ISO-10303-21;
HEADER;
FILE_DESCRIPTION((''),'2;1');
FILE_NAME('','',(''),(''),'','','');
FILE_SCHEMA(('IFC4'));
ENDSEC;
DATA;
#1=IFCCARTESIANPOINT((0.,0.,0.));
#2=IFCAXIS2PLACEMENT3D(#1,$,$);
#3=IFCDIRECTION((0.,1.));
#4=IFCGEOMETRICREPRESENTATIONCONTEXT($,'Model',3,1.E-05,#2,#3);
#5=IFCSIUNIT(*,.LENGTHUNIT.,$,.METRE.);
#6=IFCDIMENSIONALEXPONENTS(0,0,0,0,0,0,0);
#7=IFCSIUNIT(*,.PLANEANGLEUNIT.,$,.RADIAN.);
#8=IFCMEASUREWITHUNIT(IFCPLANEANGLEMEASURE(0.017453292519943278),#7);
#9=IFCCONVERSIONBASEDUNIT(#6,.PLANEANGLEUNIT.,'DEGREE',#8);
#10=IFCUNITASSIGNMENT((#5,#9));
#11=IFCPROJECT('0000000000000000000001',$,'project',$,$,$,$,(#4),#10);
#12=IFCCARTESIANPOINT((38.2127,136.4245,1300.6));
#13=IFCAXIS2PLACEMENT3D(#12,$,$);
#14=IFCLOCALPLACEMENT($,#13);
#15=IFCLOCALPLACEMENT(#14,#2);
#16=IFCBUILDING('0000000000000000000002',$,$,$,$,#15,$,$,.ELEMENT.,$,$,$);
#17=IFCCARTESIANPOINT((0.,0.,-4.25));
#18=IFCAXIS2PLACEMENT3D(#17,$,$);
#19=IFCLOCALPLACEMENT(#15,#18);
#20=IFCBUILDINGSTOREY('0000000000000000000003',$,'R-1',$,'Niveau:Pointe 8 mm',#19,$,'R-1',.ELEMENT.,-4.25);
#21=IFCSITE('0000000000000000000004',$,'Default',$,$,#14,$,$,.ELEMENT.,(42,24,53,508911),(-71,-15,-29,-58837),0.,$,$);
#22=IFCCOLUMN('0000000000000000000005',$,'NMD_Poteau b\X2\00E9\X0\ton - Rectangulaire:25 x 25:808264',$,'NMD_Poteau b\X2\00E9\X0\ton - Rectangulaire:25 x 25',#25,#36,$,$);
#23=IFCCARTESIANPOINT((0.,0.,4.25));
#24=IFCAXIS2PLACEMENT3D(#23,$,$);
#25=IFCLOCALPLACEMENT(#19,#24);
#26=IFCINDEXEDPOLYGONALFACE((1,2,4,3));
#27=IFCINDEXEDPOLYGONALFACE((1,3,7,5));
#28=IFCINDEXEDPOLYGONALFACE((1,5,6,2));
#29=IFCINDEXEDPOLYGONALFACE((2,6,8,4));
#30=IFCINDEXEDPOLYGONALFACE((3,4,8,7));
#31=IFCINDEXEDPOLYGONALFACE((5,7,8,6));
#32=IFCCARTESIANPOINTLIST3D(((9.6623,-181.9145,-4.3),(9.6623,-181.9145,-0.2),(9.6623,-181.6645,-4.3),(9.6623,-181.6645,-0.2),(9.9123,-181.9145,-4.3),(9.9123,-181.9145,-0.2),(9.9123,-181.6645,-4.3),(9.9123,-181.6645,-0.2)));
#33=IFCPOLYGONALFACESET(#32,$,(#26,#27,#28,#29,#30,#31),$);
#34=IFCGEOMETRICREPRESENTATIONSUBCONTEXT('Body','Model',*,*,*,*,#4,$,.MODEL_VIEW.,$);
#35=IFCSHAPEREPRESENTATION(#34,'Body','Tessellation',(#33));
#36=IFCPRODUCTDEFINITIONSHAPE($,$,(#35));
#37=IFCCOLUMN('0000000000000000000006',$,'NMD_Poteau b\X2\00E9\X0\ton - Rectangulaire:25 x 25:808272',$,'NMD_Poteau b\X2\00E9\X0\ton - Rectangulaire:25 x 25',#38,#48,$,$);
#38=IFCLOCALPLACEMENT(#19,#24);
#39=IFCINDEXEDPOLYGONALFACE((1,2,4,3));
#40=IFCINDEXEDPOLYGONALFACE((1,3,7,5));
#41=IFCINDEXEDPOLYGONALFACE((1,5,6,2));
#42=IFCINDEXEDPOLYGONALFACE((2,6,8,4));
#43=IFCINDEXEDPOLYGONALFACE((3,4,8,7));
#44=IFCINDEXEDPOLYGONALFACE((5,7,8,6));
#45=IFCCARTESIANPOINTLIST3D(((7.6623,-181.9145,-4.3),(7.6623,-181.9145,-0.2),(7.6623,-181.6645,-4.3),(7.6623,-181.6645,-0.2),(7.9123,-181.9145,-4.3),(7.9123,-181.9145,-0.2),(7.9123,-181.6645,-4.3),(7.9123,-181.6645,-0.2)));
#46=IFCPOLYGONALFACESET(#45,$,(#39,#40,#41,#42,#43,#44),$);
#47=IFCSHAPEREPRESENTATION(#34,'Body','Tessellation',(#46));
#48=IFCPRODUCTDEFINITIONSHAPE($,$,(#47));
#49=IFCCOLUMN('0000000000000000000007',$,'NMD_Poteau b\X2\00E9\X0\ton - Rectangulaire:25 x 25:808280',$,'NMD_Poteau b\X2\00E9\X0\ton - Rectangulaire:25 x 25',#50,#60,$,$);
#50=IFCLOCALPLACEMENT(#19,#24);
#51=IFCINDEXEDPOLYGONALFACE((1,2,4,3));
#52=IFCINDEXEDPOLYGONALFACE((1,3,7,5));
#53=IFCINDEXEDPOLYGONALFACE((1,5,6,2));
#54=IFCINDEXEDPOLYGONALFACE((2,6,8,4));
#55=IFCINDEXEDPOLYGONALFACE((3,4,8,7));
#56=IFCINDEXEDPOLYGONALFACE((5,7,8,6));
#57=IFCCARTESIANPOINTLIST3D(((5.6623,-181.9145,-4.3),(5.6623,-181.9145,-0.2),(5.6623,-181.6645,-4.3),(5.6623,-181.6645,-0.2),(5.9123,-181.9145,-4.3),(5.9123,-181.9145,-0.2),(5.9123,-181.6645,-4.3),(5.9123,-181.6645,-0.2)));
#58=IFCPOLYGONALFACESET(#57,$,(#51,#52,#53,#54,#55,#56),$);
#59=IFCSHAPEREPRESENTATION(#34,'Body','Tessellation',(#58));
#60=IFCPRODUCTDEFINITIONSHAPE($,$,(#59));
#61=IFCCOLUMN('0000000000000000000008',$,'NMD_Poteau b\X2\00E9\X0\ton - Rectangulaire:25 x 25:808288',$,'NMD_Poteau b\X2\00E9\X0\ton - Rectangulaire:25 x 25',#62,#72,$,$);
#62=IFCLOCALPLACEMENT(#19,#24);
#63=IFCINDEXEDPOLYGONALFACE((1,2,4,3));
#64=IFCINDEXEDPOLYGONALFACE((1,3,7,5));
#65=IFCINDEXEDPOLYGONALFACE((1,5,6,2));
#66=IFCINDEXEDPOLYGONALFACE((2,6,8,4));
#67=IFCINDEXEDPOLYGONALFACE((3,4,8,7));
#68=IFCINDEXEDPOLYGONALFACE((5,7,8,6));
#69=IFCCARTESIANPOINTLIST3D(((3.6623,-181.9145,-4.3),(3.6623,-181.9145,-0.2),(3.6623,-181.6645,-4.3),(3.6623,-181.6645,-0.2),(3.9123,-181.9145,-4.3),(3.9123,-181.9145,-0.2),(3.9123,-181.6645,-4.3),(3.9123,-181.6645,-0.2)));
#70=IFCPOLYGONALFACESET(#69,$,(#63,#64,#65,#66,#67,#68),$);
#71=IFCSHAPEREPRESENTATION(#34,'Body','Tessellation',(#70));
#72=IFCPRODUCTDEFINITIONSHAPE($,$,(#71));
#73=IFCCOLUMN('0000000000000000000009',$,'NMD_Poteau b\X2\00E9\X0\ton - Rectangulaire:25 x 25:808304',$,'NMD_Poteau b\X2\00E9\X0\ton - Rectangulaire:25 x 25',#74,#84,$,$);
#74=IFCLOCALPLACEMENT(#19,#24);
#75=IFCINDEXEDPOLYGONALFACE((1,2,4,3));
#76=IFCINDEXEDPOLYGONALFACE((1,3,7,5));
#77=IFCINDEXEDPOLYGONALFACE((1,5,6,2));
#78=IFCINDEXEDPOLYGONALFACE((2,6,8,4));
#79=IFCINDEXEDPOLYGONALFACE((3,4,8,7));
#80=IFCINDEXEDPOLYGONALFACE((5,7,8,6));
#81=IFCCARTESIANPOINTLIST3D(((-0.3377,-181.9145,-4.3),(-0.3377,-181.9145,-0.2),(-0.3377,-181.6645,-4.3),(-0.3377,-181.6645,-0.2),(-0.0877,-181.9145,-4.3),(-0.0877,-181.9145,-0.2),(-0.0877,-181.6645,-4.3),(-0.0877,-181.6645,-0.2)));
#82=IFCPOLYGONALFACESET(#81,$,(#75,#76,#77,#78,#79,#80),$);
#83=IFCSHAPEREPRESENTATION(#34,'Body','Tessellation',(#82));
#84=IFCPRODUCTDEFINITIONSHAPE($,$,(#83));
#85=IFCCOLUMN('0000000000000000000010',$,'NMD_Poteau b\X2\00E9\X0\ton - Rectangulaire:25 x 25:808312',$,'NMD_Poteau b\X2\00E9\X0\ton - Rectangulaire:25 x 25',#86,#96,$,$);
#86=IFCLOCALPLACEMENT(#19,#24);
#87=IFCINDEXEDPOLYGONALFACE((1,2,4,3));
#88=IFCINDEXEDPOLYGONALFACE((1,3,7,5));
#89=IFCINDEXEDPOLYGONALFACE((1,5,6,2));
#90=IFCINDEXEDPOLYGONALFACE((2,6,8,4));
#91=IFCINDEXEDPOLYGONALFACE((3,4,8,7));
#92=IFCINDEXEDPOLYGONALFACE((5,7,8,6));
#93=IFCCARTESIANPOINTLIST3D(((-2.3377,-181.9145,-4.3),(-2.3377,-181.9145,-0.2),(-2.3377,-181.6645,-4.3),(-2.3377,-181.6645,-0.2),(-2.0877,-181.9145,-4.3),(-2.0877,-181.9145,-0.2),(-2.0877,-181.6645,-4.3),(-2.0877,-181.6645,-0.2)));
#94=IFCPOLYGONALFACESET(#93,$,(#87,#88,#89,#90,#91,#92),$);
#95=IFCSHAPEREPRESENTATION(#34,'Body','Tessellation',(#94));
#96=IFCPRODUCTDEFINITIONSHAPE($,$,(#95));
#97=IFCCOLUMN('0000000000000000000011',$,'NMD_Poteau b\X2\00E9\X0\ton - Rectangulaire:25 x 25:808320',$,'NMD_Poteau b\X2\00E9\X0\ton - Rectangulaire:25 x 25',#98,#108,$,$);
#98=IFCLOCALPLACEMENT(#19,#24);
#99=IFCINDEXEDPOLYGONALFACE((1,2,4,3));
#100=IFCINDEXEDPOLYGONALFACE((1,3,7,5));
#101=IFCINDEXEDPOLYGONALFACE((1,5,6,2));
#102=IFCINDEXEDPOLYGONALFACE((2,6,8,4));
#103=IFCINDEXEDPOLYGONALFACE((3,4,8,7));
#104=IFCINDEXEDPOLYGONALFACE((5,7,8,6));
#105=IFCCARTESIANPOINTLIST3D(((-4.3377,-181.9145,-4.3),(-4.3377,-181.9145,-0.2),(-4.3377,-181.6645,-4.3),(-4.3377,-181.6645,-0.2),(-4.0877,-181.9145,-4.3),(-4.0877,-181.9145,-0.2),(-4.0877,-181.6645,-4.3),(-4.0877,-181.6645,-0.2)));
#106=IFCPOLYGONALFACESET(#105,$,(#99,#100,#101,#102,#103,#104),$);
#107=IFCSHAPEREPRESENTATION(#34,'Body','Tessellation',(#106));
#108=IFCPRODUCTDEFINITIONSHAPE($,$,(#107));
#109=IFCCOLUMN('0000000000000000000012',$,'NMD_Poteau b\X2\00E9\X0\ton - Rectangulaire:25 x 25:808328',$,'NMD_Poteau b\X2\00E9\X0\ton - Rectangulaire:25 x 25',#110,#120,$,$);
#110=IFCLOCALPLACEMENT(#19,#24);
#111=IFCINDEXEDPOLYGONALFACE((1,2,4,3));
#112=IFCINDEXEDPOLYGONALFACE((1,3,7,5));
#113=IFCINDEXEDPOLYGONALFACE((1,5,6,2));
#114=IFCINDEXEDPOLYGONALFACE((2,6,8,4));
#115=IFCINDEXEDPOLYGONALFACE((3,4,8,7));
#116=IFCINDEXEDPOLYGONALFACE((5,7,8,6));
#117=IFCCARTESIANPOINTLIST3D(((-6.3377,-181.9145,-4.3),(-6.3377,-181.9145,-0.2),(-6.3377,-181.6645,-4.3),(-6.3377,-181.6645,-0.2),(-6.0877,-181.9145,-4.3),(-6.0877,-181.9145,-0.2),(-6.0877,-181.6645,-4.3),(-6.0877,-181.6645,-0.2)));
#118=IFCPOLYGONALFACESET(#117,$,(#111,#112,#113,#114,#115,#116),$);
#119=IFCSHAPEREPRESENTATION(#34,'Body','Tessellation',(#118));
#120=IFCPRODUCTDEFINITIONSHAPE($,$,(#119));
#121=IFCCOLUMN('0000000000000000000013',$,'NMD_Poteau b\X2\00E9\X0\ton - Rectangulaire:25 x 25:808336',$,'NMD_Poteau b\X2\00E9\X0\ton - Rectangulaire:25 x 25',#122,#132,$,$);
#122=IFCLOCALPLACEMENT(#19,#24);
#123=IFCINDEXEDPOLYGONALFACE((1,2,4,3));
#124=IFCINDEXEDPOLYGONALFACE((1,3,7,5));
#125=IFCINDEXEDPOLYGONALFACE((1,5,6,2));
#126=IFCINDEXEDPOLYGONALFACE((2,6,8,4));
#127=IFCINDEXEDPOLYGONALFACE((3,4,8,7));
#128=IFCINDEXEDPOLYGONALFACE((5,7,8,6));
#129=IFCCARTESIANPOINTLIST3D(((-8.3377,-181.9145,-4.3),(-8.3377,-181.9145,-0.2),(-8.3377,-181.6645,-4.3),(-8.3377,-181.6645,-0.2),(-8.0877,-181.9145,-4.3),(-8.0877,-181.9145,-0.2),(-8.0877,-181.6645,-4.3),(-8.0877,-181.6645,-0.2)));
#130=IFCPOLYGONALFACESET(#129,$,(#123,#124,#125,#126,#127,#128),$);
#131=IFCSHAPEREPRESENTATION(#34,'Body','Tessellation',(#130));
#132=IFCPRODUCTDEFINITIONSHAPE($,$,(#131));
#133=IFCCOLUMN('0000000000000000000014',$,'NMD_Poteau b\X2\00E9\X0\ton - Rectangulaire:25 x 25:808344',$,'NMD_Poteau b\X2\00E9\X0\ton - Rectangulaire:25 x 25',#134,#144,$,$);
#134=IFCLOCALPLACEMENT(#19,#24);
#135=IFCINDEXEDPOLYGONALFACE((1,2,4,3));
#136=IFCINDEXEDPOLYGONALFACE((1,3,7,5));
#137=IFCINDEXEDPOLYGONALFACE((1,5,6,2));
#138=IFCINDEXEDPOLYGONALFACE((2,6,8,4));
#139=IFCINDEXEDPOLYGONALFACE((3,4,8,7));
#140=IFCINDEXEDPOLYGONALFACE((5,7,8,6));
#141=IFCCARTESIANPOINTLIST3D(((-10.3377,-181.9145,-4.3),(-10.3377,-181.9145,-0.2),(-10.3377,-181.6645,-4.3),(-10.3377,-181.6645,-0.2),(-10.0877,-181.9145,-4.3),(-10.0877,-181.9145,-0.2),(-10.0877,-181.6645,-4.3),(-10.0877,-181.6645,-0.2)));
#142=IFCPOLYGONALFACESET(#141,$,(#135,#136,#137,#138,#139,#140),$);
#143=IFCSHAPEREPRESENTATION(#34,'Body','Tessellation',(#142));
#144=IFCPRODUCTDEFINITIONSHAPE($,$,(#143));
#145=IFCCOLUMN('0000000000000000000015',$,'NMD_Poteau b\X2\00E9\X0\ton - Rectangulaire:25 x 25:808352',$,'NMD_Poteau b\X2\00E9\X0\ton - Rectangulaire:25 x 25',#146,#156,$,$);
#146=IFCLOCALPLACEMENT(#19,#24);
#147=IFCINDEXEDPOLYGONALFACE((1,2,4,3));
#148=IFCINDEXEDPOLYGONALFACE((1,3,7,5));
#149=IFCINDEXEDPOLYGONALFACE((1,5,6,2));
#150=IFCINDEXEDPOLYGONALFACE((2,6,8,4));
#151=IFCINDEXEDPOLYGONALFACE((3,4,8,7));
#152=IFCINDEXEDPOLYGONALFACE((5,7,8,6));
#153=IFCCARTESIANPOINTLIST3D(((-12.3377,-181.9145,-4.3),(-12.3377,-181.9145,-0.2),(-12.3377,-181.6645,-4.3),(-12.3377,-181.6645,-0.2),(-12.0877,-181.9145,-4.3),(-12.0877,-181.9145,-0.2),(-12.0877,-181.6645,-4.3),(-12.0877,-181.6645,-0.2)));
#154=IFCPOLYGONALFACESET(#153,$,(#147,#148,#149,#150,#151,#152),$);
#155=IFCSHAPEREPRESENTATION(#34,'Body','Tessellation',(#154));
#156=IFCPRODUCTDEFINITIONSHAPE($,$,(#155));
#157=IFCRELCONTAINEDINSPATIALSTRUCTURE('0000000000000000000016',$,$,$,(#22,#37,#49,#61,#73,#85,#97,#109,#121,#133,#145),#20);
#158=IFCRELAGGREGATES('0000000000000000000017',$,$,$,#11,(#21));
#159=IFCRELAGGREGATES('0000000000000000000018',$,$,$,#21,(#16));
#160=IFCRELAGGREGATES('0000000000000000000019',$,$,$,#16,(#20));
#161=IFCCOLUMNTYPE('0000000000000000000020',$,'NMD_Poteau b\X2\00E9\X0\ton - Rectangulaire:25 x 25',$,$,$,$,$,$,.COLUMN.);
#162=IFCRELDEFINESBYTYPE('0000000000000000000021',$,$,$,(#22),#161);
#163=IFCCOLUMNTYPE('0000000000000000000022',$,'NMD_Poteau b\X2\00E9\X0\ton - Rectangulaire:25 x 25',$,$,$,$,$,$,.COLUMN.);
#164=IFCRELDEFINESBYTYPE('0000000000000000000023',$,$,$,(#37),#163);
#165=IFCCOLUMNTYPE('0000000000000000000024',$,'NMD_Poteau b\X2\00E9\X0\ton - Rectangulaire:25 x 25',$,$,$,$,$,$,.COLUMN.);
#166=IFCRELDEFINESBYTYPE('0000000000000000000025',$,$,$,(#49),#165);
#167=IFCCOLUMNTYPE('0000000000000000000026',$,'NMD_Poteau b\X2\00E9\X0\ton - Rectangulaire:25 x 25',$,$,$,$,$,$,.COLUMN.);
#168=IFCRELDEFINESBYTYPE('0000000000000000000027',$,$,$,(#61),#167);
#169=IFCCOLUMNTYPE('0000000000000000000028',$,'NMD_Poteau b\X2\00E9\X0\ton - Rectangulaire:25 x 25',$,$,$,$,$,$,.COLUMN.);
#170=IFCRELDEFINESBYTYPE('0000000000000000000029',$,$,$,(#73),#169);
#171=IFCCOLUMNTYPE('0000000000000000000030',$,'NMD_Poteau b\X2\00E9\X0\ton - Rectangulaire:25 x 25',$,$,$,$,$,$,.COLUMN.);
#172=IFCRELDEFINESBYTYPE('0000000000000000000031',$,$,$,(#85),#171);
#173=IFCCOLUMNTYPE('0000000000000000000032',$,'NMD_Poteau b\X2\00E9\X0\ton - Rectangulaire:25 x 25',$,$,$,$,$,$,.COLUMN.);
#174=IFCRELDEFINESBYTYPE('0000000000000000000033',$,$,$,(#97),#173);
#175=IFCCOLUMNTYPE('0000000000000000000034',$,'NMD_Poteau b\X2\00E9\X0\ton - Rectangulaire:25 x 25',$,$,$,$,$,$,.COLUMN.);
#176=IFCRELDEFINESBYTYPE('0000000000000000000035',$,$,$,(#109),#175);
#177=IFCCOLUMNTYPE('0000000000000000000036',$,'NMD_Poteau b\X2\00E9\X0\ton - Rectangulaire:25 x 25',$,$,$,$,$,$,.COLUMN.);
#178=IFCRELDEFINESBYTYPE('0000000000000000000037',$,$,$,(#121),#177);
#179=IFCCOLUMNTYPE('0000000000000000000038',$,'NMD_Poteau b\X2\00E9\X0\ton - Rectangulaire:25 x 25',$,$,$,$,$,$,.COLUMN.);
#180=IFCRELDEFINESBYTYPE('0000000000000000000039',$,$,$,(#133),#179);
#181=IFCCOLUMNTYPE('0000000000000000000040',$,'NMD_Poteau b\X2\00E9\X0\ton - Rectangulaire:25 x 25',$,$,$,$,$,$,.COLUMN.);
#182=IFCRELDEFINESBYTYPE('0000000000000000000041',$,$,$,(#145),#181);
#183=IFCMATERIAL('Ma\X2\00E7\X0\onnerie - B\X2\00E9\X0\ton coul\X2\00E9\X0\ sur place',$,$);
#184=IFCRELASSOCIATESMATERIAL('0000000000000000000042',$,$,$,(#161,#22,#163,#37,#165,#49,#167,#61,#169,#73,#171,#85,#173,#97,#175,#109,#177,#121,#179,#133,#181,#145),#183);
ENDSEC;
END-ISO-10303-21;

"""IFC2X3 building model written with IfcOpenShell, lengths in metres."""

from ifc_helpers import new_model, entity, si_unit, converted_unit, direction, frame, frame_2d, origin, place, context, subcontext, project, spatial, rectangle, extrude, source, transform, mapped, material, type_object, type_shapes, element, save


model = new_model("IFC2X3")

# Units and contexts
model_context = context("Model", 3, precision=1e-05, world=origin(), true_north=direction((0.0, 1.0)))
body_context = subcontext(model_context, "Body", "Model", "MODEL_VIEW")
ifc_project = project(units=[si_unit("LENGTHUNIT", "METRE"), converted_unit("PLANEANGLEUNIT", "DEGREE", entity("IfcPlaneAngleMeasure", 0.017453292519943278), si_unit("PLANEANGLEUNIT", "RADIAN"), dimensions=[0, 0, 0, 0, 0, 0, 0])], contexts=[model_context])

# Site, building, storey
site_placement = place(None, frame((38.2127, 136.4245, 1300.6)))
site = spatial("IfcSite", under=ifc_project, at=site_placement, Name="Default", CompositionType="ELEMENT", RefLatitude=(42, 24, 53, 508911), RefLongitude=(-71, -15, -29, -58837), RefElevation=0.0)
building_placement = place(site_placement, origin())
building = spatial("IfcBuilding", under=site, at=building_placement, CompositionType="ELEMENT")
storey_placement = place(building_placement, frame((0.0, 0.0, -4.25)))
storey = spatial("IfcBuildingStorey", under=building, at=storey_placement, Name="R-1", ObjectType="Niveau:Pointe 8 mm", LongName="R-1", CompositionType="ELEMENT", Elevation=-4.25)

# Columns
ifc_material = material(Name="Maçonnerie - Béton coulé sur place")
column_type_1 = type_object("IfcColumnType", Name="NMD_Poteau béton - Rectangulaire:25 x 25", PredefinedType="COLUMN", material=ifc_material)
shared_shape_1 = source(origin(), body_context, "Body", "SweptSolid", [
    extrude(rectangle(XDim=0.25, YDim=0.25, at=frame_2d((0.0, 0.0), x_axis=(1.0, 0.0))), frame((9.7873, -181.7895, -4.3), z_axis=(0.0, 0.0, 1.0), x_axis=(-1.0, 0.0, 0.0)), (0.0, 0.0, 1.0), 4.1),
])
type_shapes(column_type_1, [shared_shape_1])
column_1_placement = place(storey_placement, frame((0.0, 0.0, 4.25)))
element("IfcColumn", 1, at=column_1_placement, inside=storey, type_object=column_type_1, material=ifc_material, Name="NMD_Poteau béton - Rectangulaire:25 x 25:808264", ObjectType="NMD_Poteau béton - Rectangulaire:25 x 25", context=body_context, shape_type="MappedRepresentation", body=[
    mapped(shared_shape_1, transform((0.0, 0.0, 0.0), scale=1.0)),
])
column_type_2 = type_object("IfcColumnType", Name="NMD_Poteau béton - Rectangulaire:25 x 25", PredefinedType="COLUMN", material=ifc_material)
shared_shape_2 = source(origin(), body_context, "Body", "SweptSolid", [
    extrude(rectangle(XDim=0.25, YDim=0.25, at=frame_2d((0.0, 0.0), x_axis=(1.0, 0.0))), frame((7.7873, -181.7895, -4.3), z_axis=(0.0, 0.0, 1.0), x_axis=(-1.0, 0.0, 0.0)), (0.0, 0.0, 1.0), 4.1),
])
type_shapes(column_type_2, [shared_shape_2])
column_2_placement = place(storey_placement, frame((0.0, 0.0, 4.25)))
element("IfcColumn", 2, at=column_2_placement, inside=storey, type_object=column_type_2, material=ifc_material, Name="NMD_Poteau béton - Rectangulaire:25 x 25:808272", ObjectType="NMD_Poteau béton - Rectangulaire:25 x 25", context=body_context, shape_type="MappedRepresentation", body=[
    mapped(shared_shape_2, transform((0.0, 0.0, 0.0), scale=1.0)),
])
column_type_3 = type_object("IfcColumnType", Name="NMD_Poteau béton - Rectangulaire:25 x 25", PredefinedType="COLUMN", material=ifc_material)
shared_shape_3 = source(origin(), body_context, "Body", "SweptSolid", [
    extrude(rectangle(XDim=0.25, YDim=0.25, at=frame_2d((0.0, 0.0), x_axis=(1.0, 0.0))), frame((5.7873, -181.7895, -4.3), z_axis=(0.0, 0.0, 1.0), x_axis=(-1.0, 0.0, 0.0)), (0.0, 0.0, 1.0), 4.1),
])
type_shapes(column_type_3, [shared_shape_3])
column_3_placement = place(storey_placement, frame((0.0, 0.0, 4.25)))
element("IfcColumn", 3, at=column_3_placement, inside=storey, type_object=column_type_3, material=ifc_material, Name="NMD_Poteau béton - Rectangulaire:25 x 25:808280", ObjectType="NMD_Poteau béton - Rectangulaire:25 x 25", context=body_context, shape_type="MappedRepresentation", body=[
    mapped(shared_shape_3, transform((0.0, 0.0, 0.0), scale=1.0)),
])
column_type_4 = type_object("IfcColumnType", Name="NMD_Poteau béton - Rectangulaire:25 x 25", PredefinedType="COLUMN", material=ifc_material)
shared_shape_4 = source(origin(), body_context, "Body", "SweptSolid", [
    extrude(rectangle(XDim=0.25, YDim=0.25, at=frame_2d((0.0, 0.0), x_axis=(1.0, 0.0))), frame((3.7873, -181.7895, -4.3), z_axis=(0.0, 0.0, 1.0), x_axis=(-1.0, 0.0, 0.0)), (0.0, 0.0, 1.0), 4.1),
])
type_shapes(column_type_4, [shared_shape_4])
column_4_placement = place(storey_placement, frame((0.0, 0.0, 4.25)))
element("IfcColumn", 4, at=column_4_placement, inside=storey, type_object=column_type_4, material=ifc_material, Name="NMD_Poteau béton - Rectangulaire:25 x 25:808288", ObjectType="NMD_Poteau béton - Rectangulaire:25 x 25", context=body_context, shape_type="MappedRepresentation", body=[
    mapped(shared_shape_4, transform((0.0, 0.0, 0.0), scale=1.0)),
])
column_type_5 = type_object("IfcColumnType", Name="NMD_Poteau béton - Rectangulaire:25 x 25", PredefinedType="COLUMN", material=ifc_material)
shared_shape_5 = source(origin(), body_context, "Body", "SweptSolid", [
    extrude(rectangle(XDim=0.25, YDim=0.25, at=frame_2d((0.0, 0.0), x_axis=(1.0, 0.0))), frame((-0.2127, -181.7895, -4.3), z_axis=(0.0, 0.0, 1.0), x_axis=(-1.0, 0.0, 0.0)), (0.0, 0.0, 1.0), 4.1),
])
type_shapes(column_type_5, [shared_shape_5])
column_5_placement = place(storey_placement, frame((0.0, 0.0, 4.25)))
element("IfcColumn", 5, at=column_5_placement, inside=storey, type_object=column_type_5, material=ifc_material, Name="NMD_Poteau béton - Rectangulaire:25 x 25:808304", ObjectType="NMD_Poteau béton - Rectangulaire:25 x 25", context=body_context, shape_type="MappedRepresentation", body=[
    mapped(shared_shape_5, transform((0.0, 0.0, 0.0), scale=1.0)),
])
column_type_6 = type_object("IfcColumnType", Name="NMD_Poteau béton - Rectangulaire:25 x 25", PredefinedType="COLUMN", material=ifc_material)
shared_shape_6 = source(origin(), body_context, "Body", "SweptSolid", [
    extrude(rectangle(XDim=0.25, YDim=0.25, at=frame_2d((0.0, 0.0), x_axis=(1.0, 0.0))), frame((-2.2127, -181.7895, -4.3), z_axis=(0.0, 0.0, 1.0), x_axis=(-1.0, 0.0, 0.0)), (0.0, 0.0, 1.0), 4.1),
])
type_shapes(column_type_6, [shared_shape_6])
column_6_placement = place(storey_placement, frame((0.0, 0.0, 4.25)))
element("IfcColumn", 6, at=column_6_placement, inside=storey, type_object=column_type_6, material=ifc_material, Name="NMD_Poteau béton - Rectangulaire:25 x 25:808312", ObjectType="NMD_Poteau béton - Rectangulaire:25 x 25", context=body_context, shape_type="MappedRepresentation", body=[
    mapped(shared_shape_6, transform((0.0, 0.0, 0.0), scale=1.0)),
])
column_type_7 = type_object("IfcColumnType", Name="NMD_Poteau béton - Rectangulaire:25 x 25", PredefinedType="COLUMN", material=ifc_material)
shared_shape_7 = source(origin(), body_context, "Body", "SweptSolid", [
    extrude(rectangle(XDim=0.25, YDim=0.25, at=frame_2d((0.0, 0.0), x_axis=(1.0, 0.0))), frame((-4.2127, -181.7895, -4.3), z_axis=(0.0, 0.0, 1.0), x_axis=(-1.0, 0.0, 0.0)), (0.0, 0.0, 1.0), 4.1),
])
type_shapes(column_type_7, [shared_shape_7])
column_7_placement = place(storey_placement, frame((0.0, 0.0, 4.25)))
element("IfcColumn", 7, at=column_7_placement, inside=storey, type_object=column_type_7, material=ifc_material, Name="NMD_Poteau béton - Rectangulaire:25 x 25:808320", ObjectType="NMD_Poteau béton - Rectangulaire:25 x 25", context=body_context, shape_type="MappedRepresentation", body=[
    mapped(shared_shape_7, transform((0.0, 0.0, 0.0), scale=1.0)),
])
column_type_8 = type_object("IfcColumnType", Name="NMD_Poteau béton - Rectangulaire:25 x 25", PredefinedType="COLUMN", material=ifc_material)
shared_shape_8 = source(origin(), body_context, "Body", "SweptSolid", [
    extrude(rectangle(XDim=0.25, YDim=0.25, at=frame_2d((0.0, 0.0), x_axis=(1.0, 0.0))), frame((-6.2127, -181.7895, -4.3), z_axis=(0.0, 0.0, 1.0), x_axis=(-1.0, 0.0, 0.0)), (0.0, 0.0, 1.0), 4.1),
])
type_shapes(column_type_8, [shared_shape_8])
column_8_placement = place(storey_placement, frame((0.0, 0.0, 4.25)))
element("IfcColumn", 8, at=column_8_placement, inside=storey, type_object=column_type_8, material=ifc_material, Name="NMD_Poteau béton - Rectangulaire:25 x 25:808328", ObjectType="NMD_Poteau béton - Rectangulaire:25 x 25", context=body_context, shape_type="MappedRepresentation", body=[
    mapped(shared_shape_8, transform((0.0, 0.0, 0.0), scale=1.0)),
])
column_type_9 = type_object("IfcColumnType", Name="NMD_Poteau béton - Rectangulaire:25 x 25", PredefinedType="COLUMN", material=ifc_material)
shared_shape_9 = source(origin(), body_context, "Body", "SweptSolid", [
    extrude(rectangle(XDim=0.25, YDim=0.25, at=frame_2d((0.0, 0.0), x_axis=(1.0, 0.0))), frame((-8.2127, -181.7895, -4.3), z_axis=(0.0, 0.0, 1.0), x_axis=(-1.0, 0.0, 0.0)), (0.0, 0.0, 1.0), 4.1),
])
type_shapes(column_type_9, [shared_shape_9])
column_9_placement = place(storey_placement, frame((0.0, 0.0, 4.25)))
element("IfcColumn", 9, at=column_9_placement, inside=storey, type_object=column_type_9, material=ifc_material, Name="NMD_Poteau béton - Rectangulaire:25 x 25:808336", ObjectType="NMD_Poteau béton - Rectangulaire:25 x 25", context=body_context, shape_type="MappedRepresentation", body=[
    mapped(shared_shape_9, transform((0.0, 0.0, 0.0), scale=1.0)),
])
column_type_10 = type_object("IfcColumnType", Name="NMD_Poteau béton - Rectangulaire:25 x 25", PredefinedType="COLUMN", material=ifc_material)
shared_shape_10 = source(origin(), body_context, "Body", "SweptSolid", [
    extrude(rectangle(XDim=0.25, YDim=0.25, at=frame_2d((0.0, 0.0), x_axis=(1.0, 0.0))), frame((-10.2127, -181.7895, -4.3), z_axis=(0.0, 0.0, 1.0), x_axis=(-1.0, 0.0, 0.0)), (0.0, 0.0, 1.0), 4.1),
])
type_shapes(column_type_10, [shared_shape_10])
column_10_placement = place(storey_placement, frame((0.0, 0.0, 4.25)))
element("IfcColumn", 10, at=column_10_placement, inside=storey, type_object=column_type_10, material=ifc_material, Name="NMD_Poteau béton - Rectangulaire:25 x 25:808344", ObjectType="NMD_Poteau béton - Rectangulaire:25 x 25", context=body_context, shape_type="MappedRepresentation", body=[
    mapped(shared_shape_10, transform((0.0, 0.0, 0.0), scale=1.0)),
])
column_type_11 = type_object("IfcColumnType", Name="NMD_Poteau béton - Rectangulaire:25 x 25", PredefinedType="COLUMN", material=ifc_material)
shared_shape_11 = source(origin(), body_context, "Body", "SweptSolid", [
    extrude(rectangle(XDim=0.25, YDim=0.25, at=frame_2d((0.0, 0.0), x_axis=(1.0, 0.0))), frame((-12.2127, -181.7895, -4.3), z_axis=(0.0, 0.0, 1.0), x_axis=(-1.0, 0.0, 0.0)), (0.0, 0.0, 1.0), 4.1),
])
type_shapes(column_type_11, [shared_shape_11])
column_11_placement = place(storey_placement, frame((0.0, 0.0, 4.25)))
element("IfcColumn", 11, at=column_11_placement, inside=storey, type_object=column_type_11, material=ifc_material, Name="NMD_Poteau béton - Rectangulaire:25 x 25:808352", ObjectType="NMD_Poteau béton - Rectangulaire:25 x 25", context=body_context, shape_type="MappedRepresentation", body=[
    mapped(shared_shape_11, transform((0.0, 0.0, 0.0), scale=1.0)),
])

save(model, "model.ifc")
